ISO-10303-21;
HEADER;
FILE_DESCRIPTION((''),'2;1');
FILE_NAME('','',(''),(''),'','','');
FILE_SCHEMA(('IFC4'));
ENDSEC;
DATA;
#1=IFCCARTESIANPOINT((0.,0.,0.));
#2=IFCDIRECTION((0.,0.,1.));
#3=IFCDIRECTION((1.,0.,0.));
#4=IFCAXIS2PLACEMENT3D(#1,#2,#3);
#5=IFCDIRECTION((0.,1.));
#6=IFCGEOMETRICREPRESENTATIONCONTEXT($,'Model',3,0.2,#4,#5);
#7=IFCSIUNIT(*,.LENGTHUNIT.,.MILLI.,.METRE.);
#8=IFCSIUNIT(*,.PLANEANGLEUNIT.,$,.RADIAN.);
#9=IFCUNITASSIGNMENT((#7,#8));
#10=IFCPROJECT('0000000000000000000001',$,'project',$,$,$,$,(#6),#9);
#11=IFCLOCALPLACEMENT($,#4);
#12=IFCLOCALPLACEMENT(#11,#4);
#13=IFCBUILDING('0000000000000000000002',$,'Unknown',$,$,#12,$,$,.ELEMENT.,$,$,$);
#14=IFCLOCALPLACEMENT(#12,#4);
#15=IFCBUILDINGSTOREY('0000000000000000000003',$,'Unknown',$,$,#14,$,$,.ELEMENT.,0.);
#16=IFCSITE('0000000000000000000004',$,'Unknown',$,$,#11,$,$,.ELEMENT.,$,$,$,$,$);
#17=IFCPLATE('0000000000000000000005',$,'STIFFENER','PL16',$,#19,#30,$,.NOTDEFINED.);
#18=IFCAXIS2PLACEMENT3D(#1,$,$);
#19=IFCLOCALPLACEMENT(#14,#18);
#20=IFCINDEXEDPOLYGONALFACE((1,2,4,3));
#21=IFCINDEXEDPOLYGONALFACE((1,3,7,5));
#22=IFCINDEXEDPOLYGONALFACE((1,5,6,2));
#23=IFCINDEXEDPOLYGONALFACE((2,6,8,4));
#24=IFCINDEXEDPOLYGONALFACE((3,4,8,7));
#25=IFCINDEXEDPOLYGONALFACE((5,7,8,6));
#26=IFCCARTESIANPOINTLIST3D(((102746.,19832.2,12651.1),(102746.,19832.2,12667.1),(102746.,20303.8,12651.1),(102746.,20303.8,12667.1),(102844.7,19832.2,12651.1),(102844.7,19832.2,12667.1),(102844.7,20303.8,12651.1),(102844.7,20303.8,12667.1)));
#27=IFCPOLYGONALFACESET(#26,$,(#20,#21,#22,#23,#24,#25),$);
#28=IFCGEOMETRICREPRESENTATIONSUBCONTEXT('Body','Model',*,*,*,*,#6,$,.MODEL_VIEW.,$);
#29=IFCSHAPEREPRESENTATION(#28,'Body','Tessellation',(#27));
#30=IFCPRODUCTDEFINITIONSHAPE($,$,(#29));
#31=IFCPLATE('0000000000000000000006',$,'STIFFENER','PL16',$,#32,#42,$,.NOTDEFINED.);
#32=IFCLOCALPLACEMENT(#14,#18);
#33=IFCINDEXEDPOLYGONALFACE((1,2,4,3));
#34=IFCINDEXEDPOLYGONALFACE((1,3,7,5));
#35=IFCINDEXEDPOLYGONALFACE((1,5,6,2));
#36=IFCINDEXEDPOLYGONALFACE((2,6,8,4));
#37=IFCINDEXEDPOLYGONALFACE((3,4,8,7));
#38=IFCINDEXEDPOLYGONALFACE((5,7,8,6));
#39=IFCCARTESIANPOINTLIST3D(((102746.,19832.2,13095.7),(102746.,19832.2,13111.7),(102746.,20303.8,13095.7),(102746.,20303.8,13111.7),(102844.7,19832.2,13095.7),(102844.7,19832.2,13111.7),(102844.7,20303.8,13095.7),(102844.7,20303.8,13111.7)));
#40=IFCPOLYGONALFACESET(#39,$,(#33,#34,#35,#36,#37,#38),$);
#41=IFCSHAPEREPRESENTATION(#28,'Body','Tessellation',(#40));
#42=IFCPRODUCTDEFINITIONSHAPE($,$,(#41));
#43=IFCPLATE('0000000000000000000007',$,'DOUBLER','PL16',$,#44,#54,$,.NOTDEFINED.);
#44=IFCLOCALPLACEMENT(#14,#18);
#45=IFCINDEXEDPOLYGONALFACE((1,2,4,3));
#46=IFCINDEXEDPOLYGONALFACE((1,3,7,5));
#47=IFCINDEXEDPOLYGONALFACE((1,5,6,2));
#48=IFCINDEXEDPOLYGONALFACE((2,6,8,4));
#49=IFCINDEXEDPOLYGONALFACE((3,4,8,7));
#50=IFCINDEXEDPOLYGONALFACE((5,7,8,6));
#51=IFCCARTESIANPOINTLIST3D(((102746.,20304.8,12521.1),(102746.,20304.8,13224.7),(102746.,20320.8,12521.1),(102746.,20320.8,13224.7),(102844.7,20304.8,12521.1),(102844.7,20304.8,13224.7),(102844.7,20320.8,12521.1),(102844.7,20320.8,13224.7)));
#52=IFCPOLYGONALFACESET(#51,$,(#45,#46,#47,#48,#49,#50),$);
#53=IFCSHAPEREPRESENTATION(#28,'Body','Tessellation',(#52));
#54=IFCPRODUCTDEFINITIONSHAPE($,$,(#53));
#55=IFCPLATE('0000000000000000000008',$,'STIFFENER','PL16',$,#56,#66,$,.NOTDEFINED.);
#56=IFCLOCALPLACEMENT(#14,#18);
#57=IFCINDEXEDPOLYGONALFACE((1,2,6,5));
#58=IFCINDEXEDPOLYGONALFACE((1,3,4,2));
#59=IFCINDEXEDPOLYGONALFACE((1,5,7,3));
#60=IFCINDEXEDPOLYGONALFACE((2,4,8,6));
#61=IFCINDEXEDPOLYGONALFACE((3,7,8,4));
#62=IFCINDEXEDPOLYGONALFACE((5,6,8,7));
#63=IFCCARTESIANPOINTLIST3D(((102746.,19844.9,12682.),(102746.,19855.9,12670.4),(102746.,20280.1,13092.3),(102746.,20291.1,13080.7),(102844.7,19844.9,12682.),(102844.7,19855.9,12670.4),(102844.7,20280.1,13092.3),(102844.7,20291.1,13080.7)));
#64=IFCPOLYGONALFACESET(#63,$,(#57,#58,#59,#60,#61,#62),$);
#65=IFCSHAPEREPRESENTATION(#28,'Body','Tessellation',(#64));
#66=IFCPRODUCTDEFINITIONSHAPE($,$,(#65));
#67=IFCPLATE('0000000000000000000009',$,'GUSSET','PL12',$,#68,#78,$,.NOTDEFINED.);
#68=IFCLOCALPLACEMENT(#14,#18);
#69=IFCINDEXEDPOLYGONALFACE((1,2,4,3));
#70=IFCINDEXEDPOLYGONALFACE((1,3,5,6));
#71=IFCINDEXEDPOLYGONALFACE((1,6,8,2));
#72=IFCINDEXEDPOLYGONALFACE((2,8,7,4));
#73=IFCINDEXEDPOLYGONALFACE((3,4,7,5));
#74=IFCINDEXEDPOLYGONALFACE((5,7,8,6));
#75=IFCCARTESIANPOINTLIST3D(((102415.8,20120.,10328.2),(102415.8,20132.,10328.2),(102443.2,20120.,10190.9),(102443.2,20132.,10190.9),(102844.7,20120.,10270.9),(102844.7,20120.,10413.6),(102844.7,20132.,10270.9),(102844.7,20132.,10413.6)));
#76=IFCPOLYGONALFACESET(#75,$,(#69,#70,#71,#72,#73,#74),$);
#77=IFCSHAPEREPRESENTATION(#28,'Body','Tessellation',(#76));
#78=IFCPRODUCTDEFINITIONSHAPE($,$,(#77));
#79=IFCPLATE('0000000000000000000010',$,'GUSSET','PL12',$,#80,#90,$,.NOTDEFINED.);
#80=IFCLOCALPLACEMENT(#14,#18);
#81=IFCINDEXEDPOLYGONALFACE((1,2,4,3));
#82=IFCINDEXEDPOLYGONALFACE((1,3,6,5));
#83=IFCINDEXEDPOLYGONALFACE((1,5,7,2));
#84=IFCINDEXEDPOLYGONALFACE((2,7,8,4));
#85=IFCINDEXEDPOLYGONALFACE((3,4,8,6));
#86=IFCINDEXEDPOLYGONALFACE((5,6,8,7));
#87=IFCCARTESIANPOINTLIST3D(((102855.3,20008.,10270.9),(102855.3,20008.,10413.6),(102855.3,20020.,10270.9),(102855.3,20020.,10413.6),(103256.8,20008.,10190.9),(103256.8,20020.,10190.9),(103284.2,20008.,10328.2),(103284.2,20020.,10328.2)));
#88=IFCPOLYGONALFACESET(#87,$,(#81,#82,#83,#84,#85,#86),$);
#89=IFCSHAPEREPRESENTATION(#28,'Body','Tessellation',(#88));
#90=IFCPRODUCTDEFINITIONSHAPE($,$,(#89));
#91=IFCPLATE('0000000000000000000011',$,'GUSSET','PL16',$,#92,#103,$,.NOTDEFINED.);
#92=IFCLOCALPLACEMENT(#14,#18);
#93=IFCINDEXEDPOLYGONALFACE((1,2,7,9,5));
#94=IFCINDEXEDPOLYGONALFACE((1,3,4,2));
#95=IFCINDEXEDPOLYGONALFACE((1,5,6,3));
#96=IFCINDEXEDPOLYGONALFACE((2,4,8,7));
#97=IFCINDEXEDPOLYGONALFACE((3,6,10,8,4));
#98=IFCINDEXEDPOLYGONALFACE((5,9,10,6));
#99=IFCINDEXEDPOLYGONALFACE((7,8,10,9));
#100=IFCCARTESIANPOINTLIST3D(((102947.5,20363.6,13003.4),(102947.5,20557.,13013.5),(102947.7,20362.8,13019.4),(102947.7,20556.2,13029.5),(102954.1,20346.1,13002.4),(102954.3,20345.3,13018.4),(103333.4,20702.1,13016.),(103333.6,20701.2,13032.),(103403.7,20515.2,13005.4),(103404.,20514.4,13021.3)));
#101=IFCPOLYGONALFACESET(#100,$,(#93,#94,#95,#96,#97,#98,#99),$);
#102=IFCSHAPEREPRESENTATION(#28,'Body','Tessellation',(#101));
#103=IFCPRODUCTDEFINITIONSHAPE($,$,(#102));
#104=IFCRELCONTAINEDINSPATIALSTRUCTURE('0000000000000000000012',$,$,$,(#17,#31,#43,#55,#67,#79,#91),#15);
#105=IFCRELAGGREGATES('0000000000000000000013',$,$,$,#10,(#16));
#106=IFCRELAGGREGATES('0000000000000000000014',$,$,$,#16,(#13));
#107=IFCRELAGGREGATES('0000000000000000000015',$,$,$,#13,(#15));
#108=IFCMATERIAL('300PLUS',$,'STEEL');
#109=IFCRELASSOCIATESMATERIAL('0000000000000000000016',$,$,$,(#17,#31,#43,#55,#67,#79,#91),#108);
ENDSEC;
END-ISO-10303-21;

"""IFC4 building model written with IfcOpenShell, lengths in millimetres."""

from ifc_helpers import new_model, si_unit, direction, frame, origin_with_axes, place, context, subcontext, project, spatial, line, indexed_curve, outline, extrude, material, element, save


model = new_model("IFC4")

# Units and contexts
model_context = context("Model", 3, precision=0.2, world=origin_with_axes(), true_north=direction((0.0, 1.0)))
body_context = subcontext(model_context, "Body", "Model", "MODEL_VIEW")
ifc_project = project(units=[si_unit("LENGTHUNIT", "METRE", prefix="MILLI"), si_unit("PLANEANGLEUNIT", "RADIAN")], contexts=[model_context])

# Site, building, storey
site_placement = place(None, origin_with_axes())
site = spatial("IfcSite", under=ifc_project, at=site_placement, Name="Unknown", CompositionType="ELEMENT")
building_placement = place(site_placement, origin_with_axes())
building = spatial("IfcBuilding", under=site, at=building_placement, Name="Unknown", CompositionType="ELEMENT")
storey_placement = place(building_placement, origin_with_axes())
storey = spatial("IfcBuildingStorey", under=building, at=storey_placement, Name="Unknown", CompositionType="ELEMENT", Elevation=0.0)

# Shared definitions
ifc_material_1 = material(Name="300PLUS", Category="STEEL")

# Plates
for number, where, z_axis, x_axis, name in (
    (1, (102844.7, 19832.2, 12659.1), (0.0, 0.0, 1.0), (0.0, 1.0, 0.0), "STIFFENER"),
    (2, (102844.7, 19832.2, 13103.7), (0.0, 0.0, 1.0), (0.0, 1.0, 0.0), "STIFFENER"),
):
    element("IfcPlate", number, at=place(storey_placement, frame(where, z_axis=z_axis, x_axis=x_axis)), inside=storey, material=ifc_material_1, Name=name, Description="PL16", PredefinedType="NOTDEFINED", context=body_context, shape_type="SolidModel", body=[
        extrude(outline(indexed_curve([(0.0, 0.0), (471.6, 0.0), (471.6, 98.7), (0.0, 98.7)], segments=[line(1, 2, 3, 4, 1)])), frame((0.0, 0.0, 8.0), z_axis=(0.0, 0.0, 1.0), x_axis=(1.0, 0.0, 0.0)), (0.0, 0.0, -1.0), 16.0),
    ])
plate_1_placement = place(storey_placement, frame((102844.7, 20312.8, 13224.7), z_axis=(0.0, -1.0, 0.0), x_axis=(-1.0, 0.0, 0.0)))
element("IfcPlate", 3, at=plate_1_placement, inside=storey, material=ifc_material_1, Name="DOUBLER", Description="PL16", PredefinedType="NOTDEFINED", context=body_context, shape_type="SolidModel", body=[
    extrude(outline(indexed_curve([(0.0, 0.0), (98.7, 0.0), (98.7, 703.6), (0.0, 703.6)], segments=[line(1, 2, 3, 4, 1)])), frame((0.0, 0.0, 8.0), z_axis=(0.0, 0.0, 1.0), x_axis=(1.0, 0.0, 0.0)), (0.0, 0.0, -1.0), 16.0),
])
plate_2_placement = place(storey_placement, frame((102844.7, 19850.4, 12676.2), z_axis=(0.0, -0.685985, 0.727616), x_axis=(0.0, 0.727616, 0.685985)))
element("IfcPlate", 4, at=plate_2_placement, inside=storey, material=ifc_material_1, Name="STIFFENER", Description="PL16", PredefinedType="NOTDEFINED", context=body_context, shape_type="SolidModel", body=[
    extrude(outline(indexed_curve([(0.0, 0.0), (598.1, 0.0), (598.1, 98.7), (0.0, 98.7)], segments=[line(1, 2, 3, 4, 1)])), frame((0.0, 0.0, 8.0), z_axis=(0.0, 0.0, 1.0), x_axis=(1.0, 0.0, 0.0)), (0.0, 0.0, -1.0), 16.0),
])
for number, where, z_axis, x_axis, name in (
    (5, (102844.7, 20126.0, 10270.9), (0.0, 1.0, 0.0), (-0.980721, 0.0, -0.195411), "GUSSET"),
    (6, (102855.3, 20014.0, 10270.9), (0.0, -1.0, 0.0), (0.980721, 0.0, -0.195411), "GUSSET"),
):
    element("IfcPlate", number, at=place(storey_placement, frame(where, z_axis=z_axis, x_axis=x_axis)), inside=storey, material=ifc_material_1, Name=name, Description="PL12", PredefinedType="NOTDEFINED", context=body_context, shape_type="SolidModel", body=[
        extrude(outline(indexed_curve([(0.0, 0.0), (409.4, 0.0), (409.4, 140.0), (-27.9, 139.9)], segments=[line(1, 2, 3, 4, 1)])), frame((0.0, 0.0, 6.0), z_axis=(0.0, 0.0, 1.0), x_axis=(1.0, 0.0, 0.0)), (0.0, 0.0, -1.0), 12.0),
    ])
plate_3_placement = place(storey_placement, frame((102947.6, 20363.2, 13011.4), z_axis=(0.013025, -0.052148, 0.998554), x_axis=(0.352377, -0.934334, -0.053391)))
element("IfcPlate", 7, at=plate_3_placement, inside=storey, material=ifc_material_1, Name="GUSSET", Description="PL16", PredefinedType="NOTDEFINED", context=body_context, shape_type="SolidModel", body=[
    extrude(outline(indexed_curve([(0.0, 0.0), (18.7, 0.0), (19.0, 480.4), (-181.0, 480.5), (-181.2, 68.2)], segments=[line(1, 2, 3, 4, 5, 1)])), frame((0.0, 0.0, 8.0), z_axis=(0.0, 0.0, 1.0), x_axis=(1.0, 0.0, 0.0)), (0.0, 0.0, -1.0), 16.0),
])

save(model, "model.ifc")
